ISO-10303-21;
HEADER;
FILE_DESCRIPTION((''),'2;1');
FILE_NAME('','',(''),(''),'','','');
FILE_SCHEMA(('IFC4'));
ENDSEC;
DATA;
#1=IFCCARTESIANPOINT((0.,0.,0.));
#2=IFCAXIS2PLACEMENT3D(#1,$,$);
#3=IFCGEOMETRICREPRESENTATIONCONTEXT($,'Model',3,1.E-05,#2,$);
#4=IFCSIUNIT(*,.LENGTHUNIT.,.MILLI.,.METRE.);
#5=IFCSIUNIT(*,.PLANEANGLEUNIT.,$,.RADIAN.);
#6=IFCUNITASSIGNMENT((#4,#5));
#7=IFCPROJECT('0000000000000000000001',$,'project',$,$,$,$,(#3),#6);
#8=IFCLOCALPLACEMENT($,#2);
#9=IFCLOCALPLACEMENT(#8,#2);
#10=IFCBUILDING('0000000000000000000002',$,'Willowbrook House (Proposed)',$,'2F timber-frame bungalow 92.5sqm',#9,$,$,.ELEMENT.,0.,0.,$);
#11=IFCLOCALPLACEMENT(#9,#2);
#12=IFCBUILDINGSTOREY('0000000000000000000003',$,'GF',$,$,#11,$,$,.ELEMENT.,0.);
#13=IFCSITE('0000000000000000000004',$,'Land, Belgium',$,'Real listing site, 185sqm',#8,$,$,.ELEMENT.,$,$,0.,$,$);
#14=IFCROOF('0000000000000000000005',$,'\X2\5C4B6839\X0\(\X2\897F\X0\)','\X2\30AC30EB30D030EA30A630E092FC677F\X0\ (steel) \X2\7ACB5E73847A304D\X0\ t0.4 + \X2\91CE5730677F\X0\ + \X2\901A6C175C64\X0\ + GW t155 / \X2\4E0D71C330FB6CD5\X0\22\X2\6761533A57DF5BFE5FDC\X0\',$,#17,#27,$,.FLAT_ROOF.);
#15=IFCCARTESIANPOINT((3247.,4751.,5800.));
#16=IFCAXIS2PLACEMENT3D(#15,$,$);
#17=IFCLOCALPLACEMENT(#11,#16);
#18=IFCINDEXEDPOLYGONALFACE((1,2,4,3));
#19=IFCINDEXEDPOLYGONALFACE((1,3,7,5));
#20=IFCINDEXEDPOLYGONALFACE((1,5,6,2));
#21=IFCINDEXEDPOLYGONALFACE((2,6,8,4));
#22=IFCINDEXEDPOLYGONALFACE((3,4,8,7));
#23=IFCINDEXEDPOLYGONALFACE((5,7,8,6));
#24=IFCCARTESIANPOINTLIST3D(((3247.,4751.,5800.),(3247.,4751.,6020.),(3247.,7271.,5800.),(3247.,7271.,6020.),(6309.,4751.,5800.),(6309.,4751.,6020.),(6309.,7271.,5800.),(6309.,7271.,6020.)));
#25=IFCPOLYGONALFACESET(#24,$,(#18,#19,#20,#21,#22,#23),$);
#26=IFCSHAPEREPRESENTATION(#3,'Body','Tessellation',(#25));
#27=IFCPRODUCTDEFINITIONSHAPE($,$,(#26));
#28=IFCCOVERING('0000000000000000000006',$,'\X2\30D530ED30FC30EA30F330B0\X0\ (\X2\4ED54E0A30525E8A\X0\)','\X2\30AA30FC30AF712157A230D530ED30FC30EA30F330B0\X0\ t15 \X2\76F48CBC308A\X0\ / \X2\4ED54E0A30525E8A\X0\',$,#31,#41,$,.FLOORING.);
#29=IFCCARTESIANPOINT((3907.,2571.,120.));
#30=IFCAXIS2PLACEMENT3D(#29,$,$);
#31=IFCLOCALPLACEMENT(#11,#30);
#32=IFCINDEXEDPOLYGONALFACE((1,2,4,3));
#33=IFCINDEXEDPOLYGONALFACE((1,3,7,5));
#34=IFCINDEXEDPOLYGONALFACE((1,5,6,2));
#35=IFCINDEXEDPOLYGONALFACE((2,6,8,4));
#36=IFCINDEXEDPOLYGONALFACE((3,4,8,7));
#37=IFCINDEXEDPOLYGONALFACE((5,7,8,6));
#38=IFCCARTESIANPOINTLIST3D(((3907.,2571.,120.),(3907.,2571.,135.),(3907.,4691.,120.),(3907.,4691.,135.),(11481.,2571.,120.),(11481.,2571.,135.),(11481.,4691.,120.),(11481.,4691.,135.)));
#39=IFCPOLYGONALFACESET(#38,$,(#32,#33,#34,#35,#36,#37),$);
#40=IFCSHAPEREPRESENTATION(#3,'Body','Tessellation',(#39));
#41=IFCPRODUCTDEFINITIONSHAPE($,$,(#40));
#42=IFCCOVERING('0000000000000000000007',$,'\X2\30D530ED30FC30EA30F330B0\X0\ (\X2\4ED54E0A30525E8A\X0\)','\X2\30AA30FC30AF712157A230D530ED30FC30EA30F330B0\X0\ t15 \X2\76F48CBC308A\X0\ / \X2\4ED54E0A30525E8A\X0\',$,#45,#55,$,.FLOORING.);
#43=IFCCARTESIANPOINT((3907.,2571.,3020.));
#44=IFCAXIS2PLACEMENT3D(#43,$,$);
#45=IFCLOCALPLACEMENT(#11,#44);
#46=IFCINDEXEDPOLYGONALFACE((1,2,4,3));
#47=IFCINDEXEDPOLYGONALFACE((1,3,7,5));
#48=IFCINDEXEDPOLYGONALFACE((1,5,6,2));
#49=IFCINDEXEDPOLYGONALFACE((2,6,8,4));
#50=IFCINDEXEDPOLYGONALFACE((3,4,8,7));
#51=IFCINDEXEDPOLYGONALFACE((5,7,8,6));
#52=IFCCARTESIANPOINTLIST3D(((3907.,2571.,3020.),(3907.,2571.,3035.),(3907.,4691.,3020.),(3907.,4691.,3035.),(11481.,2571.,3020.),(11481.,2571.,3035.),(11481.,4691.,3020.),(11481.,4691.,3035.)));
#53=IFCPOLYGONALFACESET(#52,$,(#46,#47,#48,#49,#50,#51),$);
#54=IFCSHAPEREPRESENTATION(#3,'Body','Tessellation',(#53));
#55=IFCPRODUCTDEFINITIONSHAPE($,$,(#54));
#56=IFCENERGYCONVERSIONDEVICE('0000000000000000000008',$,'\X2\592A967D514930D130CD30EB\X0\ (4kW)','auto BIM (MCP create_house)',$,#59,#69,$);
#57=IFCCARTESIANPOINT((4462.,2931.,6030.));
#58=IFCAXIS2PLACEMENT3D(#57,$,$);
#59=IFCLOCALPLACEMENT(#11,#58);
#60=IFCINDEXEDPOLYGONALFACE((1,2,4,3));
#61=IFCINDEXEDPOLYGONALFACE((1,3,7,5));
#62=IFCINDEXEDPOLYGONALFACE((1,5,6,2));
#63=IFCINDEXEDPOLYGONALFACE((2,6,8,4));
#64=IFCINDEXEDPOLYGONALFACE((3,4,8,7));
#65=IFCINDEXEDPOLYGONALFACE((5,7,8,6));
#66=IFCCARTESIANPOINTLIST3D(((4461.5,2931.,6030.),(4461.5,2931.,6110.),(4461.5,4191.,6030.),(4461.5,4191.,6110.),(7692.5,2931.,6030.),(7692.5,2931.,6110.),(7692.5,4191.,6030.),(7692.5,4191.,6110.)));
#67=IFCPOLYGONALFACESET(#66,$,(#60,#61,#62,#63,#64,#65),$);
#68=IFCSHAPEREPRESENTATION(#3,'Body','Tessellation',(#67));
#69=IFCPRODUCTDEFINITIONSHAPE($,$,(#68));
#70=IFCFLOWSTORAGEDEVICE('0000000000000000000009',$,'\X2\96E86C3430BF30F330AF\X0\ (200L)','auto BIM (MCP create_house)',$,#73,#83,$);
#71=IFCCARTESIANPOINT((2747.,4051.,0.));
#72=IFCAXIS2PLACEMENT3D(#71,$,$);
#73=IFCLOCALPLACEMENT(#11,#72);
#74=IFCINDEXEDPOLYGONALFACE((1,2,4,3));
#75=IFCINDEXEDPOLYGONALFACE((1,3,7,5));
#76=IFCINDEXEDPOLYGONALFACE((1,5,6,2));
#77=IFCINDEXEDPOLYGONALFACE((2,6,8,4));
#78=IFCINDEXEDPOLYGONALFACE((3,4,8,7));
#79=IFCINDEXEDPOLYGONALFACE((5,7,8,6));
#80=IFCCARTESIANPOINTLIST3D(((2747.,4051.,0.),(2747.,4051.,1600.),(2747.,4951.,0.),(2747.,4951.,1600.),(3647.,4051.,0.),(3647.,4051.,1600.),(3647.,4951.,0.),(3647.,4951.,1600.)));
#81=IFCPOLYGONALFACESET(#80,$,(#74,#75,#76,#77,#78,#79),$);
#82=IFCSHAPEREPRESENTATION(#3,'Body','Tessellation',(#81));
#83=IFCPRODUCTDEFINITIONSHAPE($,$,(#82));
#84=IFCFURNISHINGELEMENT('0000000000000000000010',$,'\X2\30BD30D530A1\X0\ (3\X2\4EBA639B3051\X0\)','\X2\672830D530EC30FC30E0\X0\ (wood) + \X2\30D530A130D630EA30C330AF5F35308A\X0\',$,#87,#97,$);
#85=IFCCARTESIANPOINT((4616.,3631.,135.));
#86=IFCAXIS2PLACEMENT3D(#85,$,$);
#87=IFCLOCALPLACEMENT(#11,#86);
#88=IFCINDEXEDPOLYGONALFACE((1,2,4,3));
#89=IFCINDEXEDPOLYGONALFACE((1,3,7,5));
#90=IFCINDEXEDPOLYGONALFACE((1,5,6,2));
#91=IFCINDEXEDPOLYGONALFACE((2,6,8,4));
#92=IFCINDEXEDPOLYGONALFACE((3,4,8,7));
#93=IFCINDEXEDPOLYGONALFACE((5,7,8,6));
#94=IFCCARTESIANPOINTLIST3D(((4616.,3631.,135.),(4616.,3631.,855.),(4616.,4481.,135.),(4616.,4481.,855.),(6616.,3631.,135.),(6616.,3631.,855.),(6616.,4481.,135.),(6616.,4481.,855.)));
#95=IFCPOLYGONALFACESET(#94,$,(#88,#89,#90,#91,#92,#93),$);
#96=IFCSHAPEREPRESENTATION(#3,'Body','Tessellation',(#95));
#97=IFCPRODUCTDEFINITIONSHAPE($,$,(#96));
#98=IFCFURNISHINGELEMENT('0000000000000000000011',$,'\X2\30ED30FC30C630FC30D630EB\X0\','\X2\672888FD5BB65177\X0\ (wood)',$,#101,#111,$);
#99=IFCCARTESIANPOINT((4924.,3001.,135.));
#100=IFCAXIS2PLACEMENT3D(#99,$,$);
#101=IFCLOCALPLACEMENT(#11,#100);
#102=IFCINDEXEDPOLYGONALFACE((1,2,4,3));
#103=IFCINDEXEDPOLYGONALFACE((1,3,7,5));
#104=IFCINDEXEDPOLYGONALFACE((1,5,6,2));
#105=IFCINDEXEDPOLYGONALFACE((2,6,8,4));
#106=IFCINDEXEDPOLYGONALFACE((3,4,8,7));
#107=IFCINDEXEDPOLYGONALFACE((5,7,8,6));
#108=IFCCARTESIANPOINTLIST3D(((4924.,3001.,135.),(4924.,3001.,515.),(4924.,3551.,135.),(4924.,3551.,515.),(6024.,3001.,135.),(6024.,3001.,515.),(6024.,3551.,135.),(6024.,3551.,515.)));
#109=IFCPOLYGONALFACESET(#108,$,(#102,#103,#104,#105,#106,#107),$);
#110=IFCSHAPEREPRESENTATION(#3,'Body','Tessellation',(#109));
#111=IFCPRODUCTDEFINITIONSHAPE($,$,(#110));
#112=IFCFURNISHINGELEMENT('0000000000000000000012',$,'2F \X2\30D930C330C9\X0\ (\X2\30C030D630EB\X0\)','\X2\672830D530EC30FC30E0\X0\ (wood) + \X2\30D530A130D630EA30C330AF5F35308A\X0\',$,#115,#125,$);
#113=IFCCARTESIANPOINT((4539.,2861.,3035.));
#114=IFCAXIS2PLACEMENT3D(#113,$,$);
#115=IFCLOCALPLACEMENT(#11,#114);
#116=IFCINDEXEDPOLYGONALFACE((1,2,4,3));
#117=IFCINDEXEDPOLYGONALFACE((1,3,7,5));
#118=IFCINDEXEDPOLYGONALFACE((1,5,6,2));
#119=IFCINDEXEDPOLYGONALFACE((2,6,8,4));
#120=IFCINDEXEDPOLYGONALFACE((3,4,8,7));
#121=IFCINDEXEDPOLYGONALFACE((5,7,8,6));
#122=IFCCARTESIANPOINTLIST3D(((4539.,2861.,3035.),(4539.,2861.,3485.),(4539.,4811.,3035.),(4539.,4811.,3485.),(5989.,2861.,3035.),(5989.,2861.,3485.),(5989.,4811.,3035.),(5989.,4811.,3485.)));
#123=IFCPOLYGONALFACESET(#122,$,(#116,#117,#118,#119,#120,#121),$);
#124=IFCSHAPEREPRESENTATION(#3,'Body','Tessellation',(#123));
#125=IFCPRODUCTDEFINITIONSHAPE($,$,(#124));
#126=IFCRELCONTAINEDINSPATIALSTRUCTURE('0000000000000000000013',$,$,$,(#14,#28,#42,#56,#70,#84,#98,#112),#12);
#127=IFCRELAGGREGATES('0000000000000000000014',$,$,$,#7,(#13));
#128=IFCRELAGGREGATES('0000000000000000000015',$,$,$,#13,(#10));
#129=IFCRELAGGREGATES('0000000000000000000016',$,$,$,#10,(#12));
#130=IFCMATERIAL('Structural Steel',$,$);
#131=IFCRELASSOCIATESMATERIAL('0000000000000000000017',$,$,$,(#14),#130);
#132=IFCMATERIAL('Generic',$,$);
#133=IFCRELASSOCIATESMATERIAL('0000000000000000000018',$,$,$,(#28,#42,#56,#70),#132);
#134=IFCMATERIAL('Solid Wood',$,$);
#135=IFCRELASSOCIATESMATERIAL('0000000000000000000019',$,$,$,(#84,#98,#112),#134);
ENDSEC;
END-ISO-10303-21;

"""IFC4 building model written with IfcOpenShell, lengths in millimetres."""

from ifc_helpers import new_model, si_unit, frame, frame_2d, origin, place, context, project, spatial, rectangle, extrude, material, element, save


model = new_model("IFC4")

# Units and contexts
model_context = context("Model", 3, precision=1e-05, world=origin())
ifc_project = project(units=[si_unit("LENGTHUNIT", "METRE", prefix="MILLI"), si_unit("PLANEANGLEUNIT", "RADIAN")], contexts=[model_context])

# Site, building, storey
site_placement = place(None, origin())
site = spatial("IfcSite", under=ifc_project, at=site_placement, Name="Land, Belgium", ObjectType="Real listing site, 185sqm", CompositionType="ELEMENT", RefElevation=0.0)
building_placement = place(site_placement, origin())
building = spatial("IfcBuilding", under=site, at=building_placement, Name="Willowbrook House (Proposed)", ObjectType="2F timber-frame bungalow 92.5sqm", CompositionType="ELEMENT", ElevationOfRefHeight=0.0, ElevationOfTerrain=0.0)
storey_placement = place(building_placement, origin())
storey = spatial("IfcBuildingStorey", under=building, at=storey_placement, Name="GF", CompositionType="ELEMENT", Elevation=0.0)

# Shared definitions
ifc_material_1 = material(Name="Solid Wood")

# Roof
ifc_material_2 = material(Name="Structural Steel")
roof_1_placement = place(storey_placement, frame((3247.0, 4751.0, 5800.0)))
element("IfcRoof", 1, at=roof_1_placement, inside=storey, material=ifc_material_2, Name="屋根(西)", Description="ガルバリウム鋼板 (steel) 立平葺き t0.4 + 野地板 + 通気層 + GW t155 / 不燃・法22条区域対応", PredefinedType="FLAT_ROOF", context=model_context, shape_type="SweptSolid", body=[
    extrude(rectangle(XDim=3062.0, YDim=2520.0, at=frame_2d((1531.0, 1260.0))), frame((3247.0, 4751.0, 5800.0)), (0.0, 0.0, 1.0), 220.0),
])

# Coverings
ifc_material_3 = material(Name="Generic")
covering_1_placement = place(storey_placement, frame((3907.0, 2571.0, 120.0)))
element("IfcCovering", 2, at=covering_1_placement, inside=storey, material=ifc_material_3, Name="フローリング (仕上げ床)", Description="オーク無垢フローリング t15 直貼り / 仕上げ床", PredefinedType="FLOORING", context=model_context, shape_type="SweptSolid", body=[
    extrude(rectangle(XDim=7574.0, YDim=2120.0, at=frame_2d((3787.0, 1060.0))), frame((3907.0, 2571.0, 120.0)), (0.0, 0.0, 1.0), 15.0),
])
covering_2_placement = place(storey_placement, frame((3907.0, 2571.0, 3020.0)))
element("IfcCovering", 3, at=covering_2_placement, inside=storey, material=ifc_material_3, Name="フローリング (仕上げ床)", Description="オーク無垢フローリング t15 直貼り / 仕上げ床", PredefinedType="FLOORING", context=model_context, shape_type="SweptSolid", body=[
    extrude(rectangle(XDim=7574.0, YDim=2120.0, at=frame_2d((3787.0, 1060.0))), frame((3907.0, 2571.0, 3020.0)), (0.0, 0.0, 1.0), 15.0),
])

# Energy conversion device
energy_conversion_device_placement = place(storey_placement, frame((4462.0, 2931.0, 6030.0)))
element("IfcEnergyConversionDevice", 4, at=energy_conversion_device_placement, inside=storey, material=ifc_material_3, Name="太陽光パネル (4kW)", Description="auto BIM (MCP create_house)", context=model_context, shape_type="SweptSolid", body=[
    extrude(rectangle(XDim=3231.0, YDim=1260.0, at=frame_2d((1615.0, 630.0))), frame((4462.0, 2931.0, 6030.0)), (0.0, 0.0, 1.0), 80.0),
])

# Flow storage device
flow_storage_device_placement = place(storey_placement, frame((2747.0, 4051.0, 0.0)))
element("IfcFlowStorageDevice", 5, at=flow_storage_device_placement, inside=storey, material=ifc_material_3, Name="雨水タンク (200L)", Description="auto BIM (MCP create_house)", context=model_context, shape_type="SweptSolid", body=[
    extrude(rectangle(XDim=900.0, YDim=900.0, at=frame_2d((450.0, 450.0))), frame((2747.0, 4051.0, 0.0)), (0.0, 0.0, 1.0), 1600.0),
])

# Furnishing elements
furnishing_1_placement = place(storey_placement, frame((4616.0, 3631.0, 135.0)))
element("IfcFurnishingElement", 6, at=furnishing_1_placement, inside=storey, material=ifc_material_1, Name="ソファ (3人掛け)", Description="木フレーム (wood) + ファブリック張り", context=model_context, shape_type="SweptSolid", body=[
    extrude(rectangle(XDim=2000.0, YDim=850.0, at=frame_2d((1000.0, 425.0))), frame((4616.0, 3631.0, 135.0)), (0.0, 0.0, 1.0), 720.0),
])
furnishing_2_placement = place(storey_placement, frame((4924.0, 3001.0, 135.0)))
element("IfcFurnishingElement", 7, at=furnishing_2_placement, inside=storey, material=ifc_material_1, Name="ローテーブル", Description="木製家具 (wood)", context=model_context, shape_type="SweptSolid", body=[
    extrude(rectangle(XDim=1100.0, YDim=550.0, at=frame_2d((550.0, 275.0))), frame((4924.0, 3001.0, 135.0)), (0.0, 0.0, 1.0), 380.0),
])
furnishing_3_placement = place(storey_placement, frame((4539.0, 2861.0, 3035.0)))
element("IfcFurnishingElement", 8, at=furnishing_3_placement, inside=storey, material=ifc_material_1, Name="2F ベッド (ダブル)", Description="木フレーム (wood) + ファブリック張り", context=model_context, shape_type="SweptSolid", body=[
    extrude(rectangle(XDim=1450.0, YDim=1950.0, at=frame_2d((725.0, 975.0))), frame((4539.0, 2861.0, 3035.0)), (0.0, 0.0, 1.0), 450.0),
])

save(model, "model.ifc")
